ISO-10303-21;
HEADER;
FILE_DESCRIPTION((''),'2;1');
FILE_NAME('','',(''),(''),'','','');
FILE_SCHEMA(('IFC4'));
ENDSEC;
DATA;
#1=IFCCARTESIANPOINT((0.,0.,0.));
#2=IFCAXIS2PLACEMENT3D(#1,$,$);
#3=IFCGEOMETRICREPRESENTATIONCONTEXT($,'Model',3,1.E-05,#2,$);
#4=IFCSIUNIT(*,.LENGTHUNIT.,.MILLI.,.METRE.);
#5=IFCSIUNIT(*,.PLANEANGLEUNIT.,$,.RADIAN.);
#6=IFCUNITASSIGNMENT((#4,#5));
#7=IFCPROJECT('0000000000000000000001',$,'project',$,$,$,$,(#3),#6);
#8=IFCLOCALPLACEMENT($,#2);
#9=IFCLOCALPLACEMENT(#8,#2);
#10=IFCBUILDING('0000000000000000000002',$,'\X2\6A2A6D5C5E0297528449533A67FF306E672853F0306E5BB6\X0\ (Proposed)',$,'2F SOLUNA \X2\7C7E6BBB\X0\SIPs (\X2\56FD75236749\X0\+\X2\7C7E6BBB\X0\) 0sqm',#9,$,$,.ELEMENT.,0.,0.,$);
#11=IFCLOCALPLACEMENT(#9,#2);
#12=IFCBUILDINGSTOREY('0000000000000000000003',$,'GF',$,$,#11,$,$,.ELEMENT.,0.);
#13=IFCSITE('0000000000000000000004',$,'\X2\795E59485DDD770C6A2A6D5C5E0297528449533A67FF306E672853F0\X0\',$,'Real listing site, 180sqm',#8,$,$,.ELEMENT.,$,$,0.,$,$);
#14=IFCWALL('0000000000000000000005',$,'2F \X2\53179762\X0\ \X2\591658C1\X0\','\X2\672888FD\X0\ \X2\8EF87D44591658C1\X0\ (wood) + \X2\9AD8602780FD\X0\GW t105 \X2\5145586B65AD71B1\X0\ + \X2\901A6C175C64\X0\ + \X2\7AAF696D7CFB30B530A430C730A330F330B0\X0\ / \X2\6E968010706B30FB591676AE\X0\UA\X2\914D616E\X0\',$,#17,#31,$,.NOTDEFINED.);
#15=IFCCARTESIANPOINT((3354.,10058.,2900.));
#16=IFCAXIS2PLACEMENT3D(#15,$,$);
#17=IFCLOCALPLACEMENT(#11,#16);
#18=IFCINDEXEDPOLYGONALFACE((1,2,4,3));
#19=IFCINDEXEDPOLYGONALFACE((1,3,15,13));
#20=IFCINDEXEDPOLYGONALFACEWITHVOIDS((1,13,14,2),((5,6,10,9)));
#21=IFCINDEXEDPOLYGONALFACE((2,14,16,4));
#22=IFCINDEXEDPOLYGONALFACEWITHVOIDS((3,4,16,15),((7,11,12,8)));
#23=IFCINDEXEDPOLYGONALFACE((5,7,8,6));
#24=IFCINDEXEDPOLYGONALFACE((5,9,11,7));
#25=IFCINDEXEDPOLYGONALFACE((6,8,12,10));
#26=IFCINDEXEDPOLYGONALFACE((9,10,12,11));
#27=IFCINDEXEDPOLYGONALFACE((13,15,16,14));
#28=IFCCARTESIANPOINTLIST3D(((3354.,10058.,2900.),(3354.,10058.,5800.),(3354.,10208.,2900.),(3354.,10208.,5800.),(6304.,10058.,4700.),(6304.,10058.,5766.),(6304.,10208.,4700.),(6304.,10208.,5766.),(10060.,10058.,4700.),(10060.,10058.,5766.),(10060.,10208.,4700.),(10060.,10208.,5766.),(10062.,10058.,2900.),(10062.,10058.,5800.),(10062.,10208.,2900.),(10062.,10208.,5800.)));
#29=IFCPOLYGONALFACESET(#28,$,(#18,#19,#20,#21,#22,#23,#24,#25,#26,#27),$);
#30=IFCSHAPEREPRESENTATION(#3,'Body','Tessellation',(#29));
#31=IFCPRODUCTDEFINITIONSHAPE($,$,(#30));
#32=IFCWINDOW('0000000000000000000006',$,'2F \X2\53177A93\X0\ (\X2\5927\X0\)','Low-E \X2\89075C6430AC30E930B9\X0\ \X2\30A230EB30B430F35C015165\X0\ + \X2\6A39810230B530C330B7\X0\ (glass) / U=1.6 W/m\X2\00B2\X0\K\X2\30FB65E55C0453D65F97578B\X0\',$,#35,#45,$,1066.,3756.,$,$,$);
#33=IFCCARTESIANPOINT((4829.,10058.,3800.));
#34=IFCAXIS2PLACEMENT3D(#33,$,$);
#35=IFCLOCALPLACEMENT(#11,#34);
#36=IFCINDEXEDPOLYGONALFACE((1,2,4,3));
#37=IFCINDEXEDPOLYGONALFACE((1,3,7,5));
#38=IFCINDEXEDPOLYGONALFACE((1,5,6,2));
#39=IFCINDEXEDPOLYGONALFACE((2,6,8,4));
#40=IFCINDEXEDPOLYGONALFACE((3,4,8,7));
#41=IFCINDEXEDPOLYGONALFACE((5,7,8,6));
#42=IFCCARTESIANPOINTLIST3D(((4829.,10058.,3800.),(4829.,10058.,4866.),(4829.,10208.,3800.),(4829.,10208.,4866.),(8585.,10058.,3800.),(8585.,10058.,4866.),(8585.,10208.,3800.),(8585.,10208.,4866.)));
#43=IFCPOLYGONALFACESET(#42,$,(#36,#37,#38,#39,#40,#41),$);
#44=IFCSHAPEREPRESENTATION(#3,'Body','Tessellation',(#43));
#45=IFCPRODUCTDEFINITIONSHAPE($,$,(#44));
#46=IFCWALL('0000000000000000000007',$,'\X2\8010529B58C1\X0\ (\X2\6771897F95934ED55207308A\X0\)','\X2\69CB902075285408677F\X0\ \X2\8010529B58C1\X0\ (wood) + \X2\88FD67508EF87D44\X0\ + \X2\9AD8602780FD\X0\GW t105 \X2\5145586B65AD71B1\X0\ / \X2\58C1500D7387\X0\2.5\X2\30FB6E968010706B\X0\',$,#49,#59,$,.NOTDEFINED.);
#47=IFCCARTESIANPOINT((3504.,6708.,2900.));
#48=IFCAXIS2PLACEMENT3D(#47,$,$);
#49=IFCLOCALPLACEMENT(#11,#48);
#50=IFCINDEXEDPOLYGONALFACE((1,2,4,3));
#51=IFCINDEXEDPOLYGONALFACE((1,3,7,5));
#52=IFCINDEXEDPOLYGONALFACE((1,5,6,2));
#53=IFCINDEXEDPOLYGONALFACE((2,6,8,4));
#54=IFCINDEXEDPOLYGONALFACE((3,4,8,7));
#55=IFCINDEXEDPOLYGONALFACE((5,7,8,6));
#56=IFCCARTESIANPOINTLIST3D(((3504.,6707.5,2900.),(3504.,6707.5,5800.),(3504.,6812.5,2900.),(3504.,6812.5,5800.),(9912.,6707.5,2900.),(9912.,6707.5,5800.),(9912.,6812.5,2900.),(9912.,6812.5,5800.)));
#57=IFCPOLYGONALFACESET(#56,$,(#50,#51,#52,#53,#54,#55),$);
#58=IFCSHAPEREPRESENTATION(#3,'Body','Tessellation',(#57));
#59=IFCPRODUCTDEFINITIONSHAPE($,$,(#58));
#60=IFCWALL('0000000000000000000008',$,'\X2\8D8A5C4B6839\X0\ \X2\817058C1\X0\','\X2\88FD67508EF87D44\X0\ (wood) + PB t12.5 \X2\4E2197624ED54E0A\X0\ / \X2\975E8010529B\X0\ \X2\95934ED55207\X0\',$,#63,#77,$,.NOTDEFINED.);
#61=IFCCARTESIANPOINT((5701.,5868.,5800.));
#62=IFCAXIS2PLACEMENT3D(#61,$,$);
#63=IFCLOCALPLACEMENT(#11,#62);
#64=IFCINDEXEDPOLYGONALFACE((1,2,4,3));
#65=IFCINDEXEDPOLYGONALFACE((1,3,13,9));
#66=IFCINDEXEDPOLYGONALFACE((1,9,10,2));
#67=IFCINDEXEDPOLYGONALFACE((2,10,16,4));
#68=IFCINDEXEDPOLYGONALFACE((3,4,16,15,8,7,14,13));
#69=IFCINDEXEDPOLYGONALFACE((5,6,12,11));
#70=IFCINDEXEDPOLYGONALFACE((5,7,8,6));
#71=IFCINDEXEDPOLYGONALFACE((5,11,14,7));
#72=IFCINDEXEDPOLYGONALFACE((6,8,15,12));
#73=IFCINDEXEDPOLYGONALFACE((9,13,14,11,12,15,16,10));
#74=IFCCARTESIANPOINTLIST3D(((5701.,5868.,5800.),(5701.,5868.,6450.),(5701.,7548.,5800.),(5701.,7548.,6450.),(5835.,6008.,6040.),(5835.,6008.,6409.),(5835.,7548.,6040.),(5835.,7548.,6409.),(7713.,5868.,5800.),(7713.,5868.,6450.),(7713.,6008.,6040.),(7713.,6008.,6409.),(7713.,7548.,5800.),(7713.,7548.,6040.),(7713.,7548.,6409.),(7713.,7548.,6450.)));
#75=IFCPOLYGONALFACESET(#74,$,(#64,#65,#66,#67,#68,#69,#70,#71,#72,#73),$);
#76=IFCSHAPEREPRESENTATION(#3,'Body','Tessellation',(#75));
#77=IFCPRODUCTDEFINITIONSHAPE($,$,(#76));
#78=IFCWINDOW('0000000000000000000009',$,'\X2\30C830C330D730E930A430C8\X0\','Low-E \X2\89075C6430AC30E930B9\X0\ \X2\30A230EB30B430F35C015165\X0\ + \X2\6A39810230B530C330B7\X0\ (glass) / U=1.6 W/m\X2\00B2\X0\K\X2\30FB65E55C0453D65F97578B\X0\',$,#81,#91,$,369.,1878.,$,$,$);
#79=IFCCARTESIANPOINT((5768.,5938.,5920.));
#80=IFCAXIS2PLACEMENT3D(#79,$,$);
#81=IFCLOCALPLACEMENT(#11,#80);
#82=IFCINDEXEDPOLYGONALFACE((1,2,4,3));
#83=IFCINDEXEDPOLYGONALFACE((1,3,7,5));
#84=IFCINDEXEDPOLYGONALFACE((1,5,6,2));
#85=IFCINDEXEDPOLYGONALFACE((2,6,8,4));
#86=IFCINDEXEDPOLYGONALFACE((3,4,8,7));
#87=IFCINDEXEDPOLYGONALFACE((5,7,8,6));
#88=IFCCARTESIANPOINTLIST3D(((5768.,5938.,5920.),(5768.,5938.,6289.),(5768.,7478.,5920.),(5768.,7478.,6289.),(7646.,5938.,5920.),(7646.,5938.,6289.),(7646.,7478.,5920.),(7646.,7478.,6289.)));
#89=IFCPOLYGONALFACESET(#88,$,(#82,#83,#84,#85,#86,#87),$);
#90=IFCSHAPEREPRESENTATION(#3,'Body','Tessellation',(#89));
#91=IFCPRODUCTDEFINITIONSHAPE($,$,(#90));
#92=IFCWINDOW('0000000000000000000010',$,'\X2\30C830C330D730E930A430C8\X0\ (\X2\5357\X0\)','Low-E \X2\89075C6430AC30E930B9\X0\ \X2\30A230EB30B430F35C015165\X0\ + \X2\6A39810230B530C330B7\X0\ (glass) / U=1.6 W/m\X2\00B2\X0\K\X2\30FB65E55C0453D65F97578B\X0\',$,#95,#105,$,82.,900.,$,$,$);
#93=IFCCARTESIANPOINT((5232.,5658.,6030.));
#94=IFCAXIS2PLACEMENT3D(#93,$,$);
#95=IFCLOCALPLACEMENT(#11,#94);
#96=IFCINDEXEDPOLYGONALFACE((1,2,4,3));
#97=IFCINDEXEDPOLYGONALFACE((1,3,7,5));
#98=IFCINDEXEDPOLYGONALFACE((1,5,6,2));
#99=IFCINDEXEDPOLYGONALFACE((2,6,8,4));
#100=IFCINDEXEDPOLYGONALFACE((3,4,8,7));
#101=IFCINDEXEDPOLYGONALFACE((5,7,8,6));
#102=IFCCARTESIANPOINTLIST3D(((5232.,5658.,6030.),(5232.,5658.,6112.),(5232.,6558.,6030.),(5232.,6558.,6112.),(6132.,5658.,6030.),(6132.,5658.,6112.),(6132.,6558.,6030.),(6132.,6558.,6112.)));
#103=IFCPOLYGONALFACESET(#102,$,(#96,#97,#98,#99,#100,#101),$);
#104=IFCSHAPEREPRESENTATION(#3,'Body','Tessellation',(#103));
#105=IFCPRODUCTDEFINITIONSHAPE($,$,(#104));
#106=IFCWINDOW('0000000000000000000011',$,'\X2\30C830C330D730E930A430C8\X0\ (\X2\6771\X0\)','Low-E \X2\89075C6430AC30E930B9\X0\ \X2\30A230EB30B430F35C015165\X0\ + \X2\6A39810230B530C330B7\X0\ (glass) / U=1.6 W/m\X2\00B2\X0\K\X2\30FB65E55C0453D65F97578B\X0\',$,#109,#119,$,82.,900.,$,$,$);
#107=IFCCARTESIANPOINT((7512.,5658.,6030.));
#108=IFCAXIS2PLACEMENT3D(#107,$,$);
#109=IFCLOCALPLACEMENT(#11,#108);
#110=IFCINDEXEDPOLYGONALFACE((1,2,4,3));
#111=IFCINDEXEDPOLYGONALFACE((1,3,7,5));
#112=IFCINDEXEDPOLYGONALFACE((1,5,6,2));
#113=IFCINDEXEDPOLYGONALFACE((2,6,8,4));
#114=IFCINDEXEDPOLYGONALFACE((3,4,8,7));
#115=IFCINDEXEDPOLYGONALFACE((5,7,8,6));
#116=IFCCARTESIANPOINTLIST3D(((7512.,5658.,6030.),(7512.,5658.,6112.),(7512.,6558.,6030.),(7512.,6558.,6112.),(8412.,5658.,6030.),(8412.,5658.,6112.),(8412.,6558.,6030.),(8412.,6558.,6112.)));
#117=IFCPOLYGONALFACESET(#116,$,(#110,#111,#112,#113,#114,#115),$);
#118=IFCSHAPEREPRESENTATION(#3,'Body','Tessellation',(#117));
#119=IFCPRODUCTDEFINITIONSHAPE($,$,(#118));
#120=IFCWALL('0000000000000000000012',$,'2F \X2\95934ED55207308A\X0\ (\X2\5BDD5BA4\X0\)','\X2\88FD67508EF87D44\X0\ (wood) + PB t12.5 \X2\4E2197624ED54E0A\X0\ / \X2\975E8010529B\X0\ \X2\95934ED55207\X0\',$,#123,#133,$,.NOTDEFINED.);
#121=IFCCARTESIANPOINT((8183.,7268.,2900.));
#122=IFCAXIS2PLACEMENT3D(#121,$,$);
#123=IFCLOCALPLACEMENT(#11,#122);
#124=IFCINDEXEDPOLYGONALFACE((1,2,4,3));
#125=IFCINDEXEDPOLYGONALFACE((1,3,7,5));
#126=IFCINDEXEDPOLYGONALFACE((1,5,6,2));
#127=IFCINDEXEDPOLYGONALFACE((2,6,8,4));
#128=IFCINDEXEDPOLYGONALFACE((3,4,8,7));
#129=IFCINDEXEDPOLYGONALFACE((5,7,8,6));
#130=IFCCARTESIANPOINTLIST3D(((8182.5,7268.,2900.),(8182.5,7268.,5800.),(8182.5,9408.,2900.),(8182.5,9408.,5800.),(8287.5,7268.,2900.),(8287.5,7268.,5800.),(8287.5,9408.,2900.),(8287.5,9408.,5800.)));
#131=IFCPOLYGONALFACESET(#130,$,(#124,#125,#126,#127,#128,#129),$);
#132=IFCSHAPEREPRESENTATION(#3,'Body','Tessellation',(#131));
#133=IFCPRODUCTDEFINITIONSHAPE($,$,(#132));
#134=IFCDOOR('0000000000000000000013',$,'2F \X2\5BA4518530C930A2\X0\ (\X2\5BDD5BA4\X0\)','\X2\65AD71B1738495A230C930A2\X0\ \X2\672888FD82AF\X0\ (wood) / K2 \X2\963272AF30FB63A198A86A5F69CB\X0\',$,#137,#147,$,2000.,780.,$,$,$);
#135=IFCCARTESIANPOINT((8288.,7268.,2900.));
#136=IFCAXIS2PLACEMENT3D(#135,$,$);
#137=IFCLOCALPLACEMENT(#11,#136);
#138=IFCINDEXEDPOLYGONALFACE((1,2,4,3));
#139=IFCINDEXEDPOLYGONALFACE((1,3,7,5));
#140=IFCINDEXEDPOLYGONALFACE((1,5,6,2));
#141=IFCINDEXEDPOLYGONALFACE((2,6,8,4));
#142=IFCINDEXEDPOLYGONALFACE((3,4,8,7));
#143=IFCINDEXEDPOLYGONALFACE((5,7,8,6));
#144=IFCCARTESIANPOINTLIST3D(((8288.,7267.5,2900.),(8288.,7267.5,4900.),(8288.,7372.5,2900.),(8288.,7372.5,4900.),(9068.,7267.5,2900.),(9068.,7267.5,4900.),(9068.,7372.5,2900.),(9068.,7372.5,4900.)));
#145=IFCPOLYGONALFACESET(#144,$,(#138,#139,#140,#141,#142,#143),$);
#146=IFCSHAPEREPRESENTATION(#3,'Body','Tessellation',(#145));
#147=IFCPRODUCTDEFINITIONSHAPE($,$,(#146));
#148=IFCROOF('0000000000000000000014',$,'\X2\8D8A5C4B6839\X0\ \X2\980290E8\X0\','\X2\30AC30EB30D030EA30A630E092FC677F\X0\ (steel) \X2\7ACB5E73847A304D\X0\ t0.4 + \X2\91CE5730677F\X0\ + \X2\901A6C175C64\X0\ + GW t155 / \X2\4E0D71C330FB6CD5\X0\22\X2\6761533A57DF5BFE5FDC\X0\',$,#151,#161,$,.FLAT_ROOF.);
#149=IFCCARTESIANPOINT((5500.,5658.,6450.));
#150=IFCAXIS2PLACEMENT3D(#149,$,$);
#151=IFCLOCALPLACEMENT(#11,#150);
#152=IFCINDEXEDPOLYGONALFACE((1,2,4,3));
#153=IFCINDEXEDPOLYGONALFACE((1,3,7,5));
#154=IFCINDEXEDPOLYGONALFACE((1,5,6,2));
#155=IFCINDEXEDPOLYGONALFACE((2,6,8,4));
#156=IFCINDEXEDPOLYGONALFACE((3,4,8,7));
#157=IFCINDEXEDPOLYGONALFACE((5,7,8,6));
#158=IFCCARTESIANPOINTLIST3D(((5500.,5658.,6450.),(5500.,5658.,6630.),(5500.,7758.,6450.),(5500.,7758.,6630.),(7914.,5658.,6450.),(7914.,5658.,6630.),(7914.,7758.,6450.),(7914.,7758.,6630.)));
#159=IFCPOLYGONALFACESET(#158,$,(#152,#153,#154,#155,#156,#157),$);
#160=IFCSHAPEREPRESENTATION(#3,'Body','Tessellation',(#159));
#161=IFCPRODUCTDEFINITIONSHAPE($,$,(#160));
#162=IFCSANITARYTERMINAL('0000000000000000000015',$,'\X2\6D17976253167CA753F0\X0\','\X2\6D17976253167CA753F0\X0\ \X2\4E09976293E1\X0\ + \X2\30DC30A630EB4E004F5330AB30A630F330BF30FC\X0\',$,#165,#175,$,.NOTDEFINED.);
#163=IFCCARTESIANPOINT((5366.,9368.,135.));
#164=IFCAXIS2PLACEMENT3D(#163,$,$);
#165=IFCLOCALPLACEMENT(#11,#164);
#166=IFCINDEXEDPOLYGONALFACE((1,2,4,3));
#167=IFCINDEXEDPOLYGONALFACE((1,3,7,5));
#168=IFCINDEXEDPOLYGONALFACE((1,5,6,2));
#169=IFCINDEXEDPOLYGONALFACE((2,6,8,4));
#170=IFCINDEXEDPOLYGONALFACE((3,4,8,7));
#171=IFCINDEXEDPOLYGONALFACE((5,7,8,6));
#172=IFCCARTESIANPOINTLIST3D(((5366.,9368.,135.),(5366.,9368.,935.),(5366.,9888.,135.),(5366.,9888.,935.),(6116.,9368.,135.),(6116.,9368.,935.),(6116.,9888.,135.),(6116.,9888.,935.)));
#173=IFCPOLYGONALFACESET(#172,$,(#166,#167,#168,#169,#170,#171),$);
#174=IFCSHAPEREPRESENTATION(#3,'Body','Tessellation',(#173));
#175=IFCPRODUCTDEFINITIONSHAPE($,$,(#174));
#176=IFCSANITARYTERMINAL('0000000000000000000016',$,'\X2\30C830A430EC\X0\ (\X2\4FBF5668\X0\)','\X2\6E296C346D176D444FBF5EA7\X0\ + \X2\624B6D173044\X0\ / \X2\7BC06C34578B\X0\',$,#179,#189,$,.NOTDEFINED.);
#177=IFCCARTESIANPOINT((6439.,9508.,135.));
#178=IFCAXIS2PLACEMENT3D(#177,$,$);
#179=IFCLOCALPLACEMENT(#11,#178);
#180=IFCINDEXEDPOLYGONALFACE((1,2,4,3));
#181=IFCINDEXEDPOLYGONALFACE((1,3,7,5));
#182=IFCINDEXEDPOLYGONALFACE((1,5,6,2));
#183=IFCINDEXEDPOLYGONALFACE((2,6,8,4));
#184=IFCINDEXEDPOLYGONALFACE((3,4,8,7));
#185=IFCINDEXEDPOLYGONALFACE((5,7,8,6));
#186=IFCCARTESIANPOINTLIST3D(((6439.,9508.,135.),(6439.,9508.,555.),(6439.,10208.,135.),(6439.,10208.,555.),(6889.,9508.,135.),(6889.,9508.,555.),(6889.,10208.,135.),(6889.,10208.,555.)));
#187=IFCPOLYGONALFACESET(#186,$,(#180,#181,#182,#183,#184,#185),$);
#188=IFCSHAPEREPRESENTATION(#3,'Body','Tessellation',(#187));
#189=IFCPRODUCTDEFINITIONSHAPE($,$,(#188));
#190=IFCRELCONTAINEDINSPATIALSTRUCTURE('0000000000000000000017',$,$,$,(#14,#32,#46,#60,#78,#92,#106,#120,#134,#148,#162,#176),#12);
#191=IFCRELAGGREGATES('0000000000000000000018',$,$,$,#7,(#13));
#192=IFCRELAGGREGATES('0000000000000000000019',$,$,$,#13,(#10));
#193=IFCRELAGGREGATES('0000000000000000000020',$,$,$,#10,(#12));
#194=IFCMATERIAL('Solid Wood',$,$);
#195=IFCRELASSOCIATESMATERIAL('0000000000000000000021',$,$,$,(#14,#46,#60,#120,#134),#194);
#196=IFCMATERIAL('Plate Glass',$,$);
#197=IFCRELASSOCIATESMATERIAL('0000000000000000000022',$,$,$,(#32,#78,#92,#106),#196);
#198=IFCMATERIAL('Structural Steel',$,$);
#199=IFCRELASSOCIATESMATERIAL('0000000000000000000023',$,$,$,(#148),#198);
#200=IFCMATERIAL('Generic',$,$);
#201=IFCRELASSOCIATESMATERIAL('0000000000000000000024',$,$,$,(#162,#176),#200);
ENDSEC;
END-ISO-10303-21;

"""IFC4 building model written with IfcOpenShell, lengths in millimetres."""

from ifc_helpers import new_model, si_unit, frame, frame_2d, origin, place, context, project, spatial, rectangle, extrude, material, element, fill, save


model = new_model("IFC4")

# Units and contexts
model_context = context("Model", 3, precision=1e-05, world=origin())
ifc_project = project(units=[si_unit("LENGTHUNIT", "METRE", prefix="MILLI"), si_unit("PLANEANGLEUNIT", "RADIAN")], contexts=[model_context])

# Site, building, storey
site_placement = place(None, origin())
site = spatial("IfcSite", under=ifc_project, at=site_placement, Name="神奈川県横浜市青葉区柿の木台", ObjectType="Real listing site, 180sqm", CompositionType="ELEMENT", RefElevation=0.0)
building_placement = place(site_placement, origin())
building = spatial("IfcBuilding", under=site, at=building_placement, Name="横浜市青葉区柿の木台の家 (Proposed)", ObjectType="2F SOLUNA 籾殻SIPs (国産杉+籾殻) 0sqm", CompositionType="ELEMENT", ElevationOfRefHeight=0.0, ElevationOfTerrain=0.0)
storey_placement = place(building_placement, origin())
storey = spatial("IfcBuildingStorey", under=building, at=storey_placement, Name="GF", CompositionType="ELEMENT", Elevation=0.0)

# Wall, opening, window
ifc_material_1 = material(Name="Solid Wood")
wall_1_placement = place(storey_placement, frame((3354.0, 10058.0, 2900.0)))
wall_1 = element("IfcWall", 1, at=wall_1_placement, inside=storey, material=ifc_material_1, Name="2F 北面 外壁", Description="木製 軸組外壁 (wood) + 高性能GW t105 充填断熱 + 通気層 + 窯業系サイディング / 準耐火・外皮UA配慮", PredefinedType="NOTDEFINED", context=model_context, shape_type="SweptSolid", body=[
    extrude(rectangle(XDim=6708.0, YDim=150.0, at=frame_2d((3354.0, 75.0))), frame((3354.0, 10058.0, 2900.0)), (0.0, 0.0, 1.0), 2900.0),
])
opening_1_placement = place(storey_placement, frame((4829.0, 10058.0, 3800.0)))
opening_1 = element("IfcOpeningElement", 2, at=opening_1_placement, cuts=wall_1, PredefinedType="NOTDEFINED", context=model_context, shape_type="SweptSolid", body=[
    extrude(rectangle(XDim=3756.0, YDim=150.0, at=frame_2d((1878.0, 75.0))), frame((4829.0, 10058.0, 3800.0)), (0.0, 0.0, 1.0), 1066.0),
])
ifc_material_2 = material(Name="Plate Glass")
window_1_placement = place(storey_placement, frame((4829.0, 10058.0, 3800.0)))
window_1 = element("IfcWindow", 3, at=window_1_placement, inside=storey, material=ifc_material_2, Name="2F 北窓 (大)", Description="Low-E 複層ガラス アルゴン封入 + 樹脂サッシ (glass) / U=1.6 W/m²K・日射取得型", OverallHeight=1066.0, OverallWidth=3756.0, context=model_context, shape_type="SweptSolid", body=[
    extrude(rectangle(XDim=3756.0, YDim=150.0, at=frame_2d((1878.0, 75.0))), frame((4829.0, 10058.0, 3800.0)), (0.0, 0.0, 1.0), 1066.0),
])
fill(opening_1, window_1)

# Wall
wall_2_placement = place(storey_placement, frame((3504.0, 6708.0, 2900.0)))
element("IfcWall", 4, at=wall_2_placement, inside=storey, material=ifc_material_1, Name="耐力壁 (東西間仕切り)", Description="構造用合板 耐力壁 (wood) + 製材軸組 + 高性能GW t105 充填断熱 / 壁倍率2.5・準耐火", PredefinedType="NOTDEFINED", context=model_context, shape_type="SweptSolid", body=[
    extrude(rectangle(XDim=6408.0, YDim=105.0, at=frame_2d((3204.0, 52.0))), frame((3504.0, 6708.0, 2900.0)), (0.0, 0.0, 1.0), 2900.0),
])

# Wall, openings, windows
wall_3_placement = place(storey_placement, frame((5701.0, 5868.0, 5800.0)))
wall_3 = element("IfcWall", 5, at=wall_3_placement, inside=storey, material=ifc_material_1, Name="越屋根 腰壁", Description="製材軸組 (wood) + PB t12.5 両面仕上 / 非耐力 間仕切", PredefinedType="NOTDEFINED", context=model_context, shape_type="SweptSolid", body=[
    extrude(rectangle(XDim=2012.0, YDim=1680.0, at=frame_2d((1006.0, 840.0))), frame((5701.0, 5868.0, 5800.0)), (0.0, 0.0, 1.0), 650.0),
])
opening_2_placement = place(storey_placement, frame((5768.0, 5938.0, 5920.0)))
opening_2 = element("IfcOpeningElement", 6, at=opening_2_placement, cuts=wall_3, PredefinedType="NOTDEFINED", context=model_context, shape_type="SweptSolid", body=[
    extrude(rectangle(XDim=1878.0, YDim=1540.0, at=frame_2d((939.0, 770.0))), frame((5768.0, 5938.0, 5920.0)), (0.0, 0.0, 1.0), 369.0),
])
opening_3_placement = place(storey_placement, frame((5232.0, 5658.0, 6030.0)))
opening_3 = element("IfcOpeningElement", 7, at=opening_3_placement, cuts=wall_3, PredefinedType="NOTDEFINED", context=model_context, shape_type="SweptSolid", body=[
    extrude(rectangle(XDim=900.0, YDim=900.0, at=frame_2d((450.0, 450.0))), frame((5232.0, 5658.0, 6030.0)), (0.0, 0.0, 1.0), 82.0),
])
opening_4_placement = place(storey_placement, frame((7512.0, 5658.0, 6030.0)))
opening_4 = element("IfcOpeningElement", 8, at=opening_4_placement, cuts=wall_3, PredefinedType="NOTDEFINED", context=model_context, shape_type="SweptSolid", body=[
    extrude(rectangle(XDim=900.0, YDim=900.0, at=frame_2d((450.0, 450.0))), frame((7512.0, 5658.0, 6030.0)), (0.0, 0.0, 1.0), 82.0),
])
window_2_placement = place(storey_placement, frame((5768.0, 5938.0, 5920.0)))
window_2 = element("IfcWindow", 9, at=window_2_placement, inside=storey, material=ifc_material_2, Name="トップライト", Description="Low-E 複層ガラス アルゴン封入 + 樹脂サッシ (glass) / U=1.6 W/m²K・日射取得型", OverallHeight=369.0, OverallWidth=1878.0, context=model_context, shape_type="SweptSolid", body=[
    extrude(rectangle(XDim=1878.0, YDim=1540.0, at=frame_2d((939.0, 770.0))), frame((5768.0, 5938.0, 5920.0)), (0.0, 0.0, 1.0), 369.0),
])
fill(opening_2, window_2)
window_3_placement = place(storey_placement, frame((5232.0, 5658.0, 6030.0)))
window_3 = element("IfcWindow", 10, at=window_3_placement, inside=storey, material=ifc_material_2, Name="トップライト (南)", Description="Low-E 複層ガラス アルゴン封入 + 樹脂サッシ (glass) / U=1.6 W/m²K・日射取得型", OverallHeight=82.0, OverallWidth=900.0, context=model_context, shape_type="SweptSolid", body=[
    extrude(rectangle(XDim=900.0, YDim=900.0, at=frame_2d((450.0, 450.0))), frame((5232.0, 5658.0, 6030.0)), (0.0, 0.0, 1.0), 82.0),
])
fill(opening_3, window_3)
window_4_placement = place(storey_placement, frame((7512.0, 5658.0, 6030.0)))
window_4 = element("IfcWindow", 11, at=window_4_placement, inside=storey, material=ifc_material_2, Name="トップライト (東)", Description="Low-E 複層ガラス アルゴン封入 + 樹脂サッシ (glass) / U=1.6 W/m²K・日射取得型", OverallHeight=82.0, OverallWidth=900.0, context=model_context, shape_type="SweptSolid", body=[
    extrude(rectangle(XDim=900.0, YDim=900.0, at=frame_2d((450.0, 450.0))), frame((7512.0, 5658.0, 6030.0)), (0.0, 0.0, 1.0), 82.0),
])
fill(opening_4, window_4)

# Wall
wall_4_placement = place(storey_placement, frame((8183.0, 7268.0, 2900.0)))
element("IfcWall", 12, at=wall_4_placement, inside=storey, material=ifc_material_1, Name="2F 間仕切り (寝室)", Description="製材軸組 (wood) + PB t12.5 両面仕上 / 非耐力 間仕切", PredefinedType="NOTDEFINED", context=model_context, shape_type="SweptSolid", body=[
    extrude(rectangle(XDim=105.0, YDim=2140.0, at=frame_2d((52.0, 1070.0))), frame((8183.0, 7268.0, 2900.0)), (0.0, 0.0, 1.0), 2900.0),
])

# Door
door_placement = place(storey_placement, frame((8288.0, 7268.0, 2900.0)))
element("IfcDoor", 13, at=door_placement, inside=storey, material=ifc_material_1, Name="2F 室内ドア (寝室)", Description="断熱玄関ドア 木製芯 (wood) / K2 防犯・採風機構", OverallHeight=2000.0, OverallWidth=780.0, context=model_context, shape_type="SweptSolid", body=[
    extrude(rectangle(XDim=780.0, YDim=105.0, at=frame_2d((390.0, 52.0))), frame((8288.0, 7268.0, 2900.0)), (0.0, 0.0, 1.0), 2000.0),
])

# Roof
ifc_material_3 = material(Name="Structural Steel")
roof_placement = place(storey_placement, frame((5500.0, 5658.0, 6450.0)))
element("IfcRoof", 14, at=roof_placement, inside=storey, material=ifc_material_3, Name="越屋根 頂部", Description="ガルバリウム鋼板 (steel) 立平葺き t0.4 + 野地板 + 通気層 + GW t155 / 不燃・法22条区域対応", PredefinedType="FLAT_ROOF", context=model_context, shape_type="SweptSolid", body=[
    extrude(rectangle(XDim=2414.0, YDim=2100.0, at=frame_2d((1207.0, 1050.0))), frame((5500.0, 5658.0, 6450.0)), (0.0, 0.0, 1.0), 180.0),
])

# Sanitary terminals
ifc_material_4 = material(Name="Generic")
sanitary_terminal_1_placement = place(storey_placement, frame((5366.0, 9368.0, 135.0)))
element("IfcSanitaryTerminal", 15, at=sanitary_terminal_1_placement, inside=storey, material=ifc_material_4, Name="洗面化粧台", Description="洗面化粧台 三面鏡 + ボウル一体カウンター", PredefinedType="NOTDEFINED", context=model_context, shape_type="SweptSolid", body=[
    extrude(rectangle(XDim=750.0, YDim=520.0, at=frame_2d((375.0, 260.0))), frame((5366.0, 9368.0, 135.0)), (0.0, 0.0, 1.0), 800.0),
])
sanitary_terminal_2_placement = place(storey_placement, frame((6439.0, 9508.0, 135.0)))
element("IfcSanitaryTerminal", 16, at=sanitary_terminal_2_placement, inside=storey, material=ifc_material_4, Name="トイレ (便器)", Description="温水洗浄便座 + 手洗い / 節水型", PredefinedType="NOTDEFINED", context=model_context, shape_type="SweptSolid", body=[
    extrude(rectangle(XDim=450.0, YDim=700.0, at=frame_2d((225.0, 350.0))), frame((6439.0, 9508.0, 135.0)), (0.0, 0.0, 1.0), 420.0),
])

save(model, "model.ifc")
